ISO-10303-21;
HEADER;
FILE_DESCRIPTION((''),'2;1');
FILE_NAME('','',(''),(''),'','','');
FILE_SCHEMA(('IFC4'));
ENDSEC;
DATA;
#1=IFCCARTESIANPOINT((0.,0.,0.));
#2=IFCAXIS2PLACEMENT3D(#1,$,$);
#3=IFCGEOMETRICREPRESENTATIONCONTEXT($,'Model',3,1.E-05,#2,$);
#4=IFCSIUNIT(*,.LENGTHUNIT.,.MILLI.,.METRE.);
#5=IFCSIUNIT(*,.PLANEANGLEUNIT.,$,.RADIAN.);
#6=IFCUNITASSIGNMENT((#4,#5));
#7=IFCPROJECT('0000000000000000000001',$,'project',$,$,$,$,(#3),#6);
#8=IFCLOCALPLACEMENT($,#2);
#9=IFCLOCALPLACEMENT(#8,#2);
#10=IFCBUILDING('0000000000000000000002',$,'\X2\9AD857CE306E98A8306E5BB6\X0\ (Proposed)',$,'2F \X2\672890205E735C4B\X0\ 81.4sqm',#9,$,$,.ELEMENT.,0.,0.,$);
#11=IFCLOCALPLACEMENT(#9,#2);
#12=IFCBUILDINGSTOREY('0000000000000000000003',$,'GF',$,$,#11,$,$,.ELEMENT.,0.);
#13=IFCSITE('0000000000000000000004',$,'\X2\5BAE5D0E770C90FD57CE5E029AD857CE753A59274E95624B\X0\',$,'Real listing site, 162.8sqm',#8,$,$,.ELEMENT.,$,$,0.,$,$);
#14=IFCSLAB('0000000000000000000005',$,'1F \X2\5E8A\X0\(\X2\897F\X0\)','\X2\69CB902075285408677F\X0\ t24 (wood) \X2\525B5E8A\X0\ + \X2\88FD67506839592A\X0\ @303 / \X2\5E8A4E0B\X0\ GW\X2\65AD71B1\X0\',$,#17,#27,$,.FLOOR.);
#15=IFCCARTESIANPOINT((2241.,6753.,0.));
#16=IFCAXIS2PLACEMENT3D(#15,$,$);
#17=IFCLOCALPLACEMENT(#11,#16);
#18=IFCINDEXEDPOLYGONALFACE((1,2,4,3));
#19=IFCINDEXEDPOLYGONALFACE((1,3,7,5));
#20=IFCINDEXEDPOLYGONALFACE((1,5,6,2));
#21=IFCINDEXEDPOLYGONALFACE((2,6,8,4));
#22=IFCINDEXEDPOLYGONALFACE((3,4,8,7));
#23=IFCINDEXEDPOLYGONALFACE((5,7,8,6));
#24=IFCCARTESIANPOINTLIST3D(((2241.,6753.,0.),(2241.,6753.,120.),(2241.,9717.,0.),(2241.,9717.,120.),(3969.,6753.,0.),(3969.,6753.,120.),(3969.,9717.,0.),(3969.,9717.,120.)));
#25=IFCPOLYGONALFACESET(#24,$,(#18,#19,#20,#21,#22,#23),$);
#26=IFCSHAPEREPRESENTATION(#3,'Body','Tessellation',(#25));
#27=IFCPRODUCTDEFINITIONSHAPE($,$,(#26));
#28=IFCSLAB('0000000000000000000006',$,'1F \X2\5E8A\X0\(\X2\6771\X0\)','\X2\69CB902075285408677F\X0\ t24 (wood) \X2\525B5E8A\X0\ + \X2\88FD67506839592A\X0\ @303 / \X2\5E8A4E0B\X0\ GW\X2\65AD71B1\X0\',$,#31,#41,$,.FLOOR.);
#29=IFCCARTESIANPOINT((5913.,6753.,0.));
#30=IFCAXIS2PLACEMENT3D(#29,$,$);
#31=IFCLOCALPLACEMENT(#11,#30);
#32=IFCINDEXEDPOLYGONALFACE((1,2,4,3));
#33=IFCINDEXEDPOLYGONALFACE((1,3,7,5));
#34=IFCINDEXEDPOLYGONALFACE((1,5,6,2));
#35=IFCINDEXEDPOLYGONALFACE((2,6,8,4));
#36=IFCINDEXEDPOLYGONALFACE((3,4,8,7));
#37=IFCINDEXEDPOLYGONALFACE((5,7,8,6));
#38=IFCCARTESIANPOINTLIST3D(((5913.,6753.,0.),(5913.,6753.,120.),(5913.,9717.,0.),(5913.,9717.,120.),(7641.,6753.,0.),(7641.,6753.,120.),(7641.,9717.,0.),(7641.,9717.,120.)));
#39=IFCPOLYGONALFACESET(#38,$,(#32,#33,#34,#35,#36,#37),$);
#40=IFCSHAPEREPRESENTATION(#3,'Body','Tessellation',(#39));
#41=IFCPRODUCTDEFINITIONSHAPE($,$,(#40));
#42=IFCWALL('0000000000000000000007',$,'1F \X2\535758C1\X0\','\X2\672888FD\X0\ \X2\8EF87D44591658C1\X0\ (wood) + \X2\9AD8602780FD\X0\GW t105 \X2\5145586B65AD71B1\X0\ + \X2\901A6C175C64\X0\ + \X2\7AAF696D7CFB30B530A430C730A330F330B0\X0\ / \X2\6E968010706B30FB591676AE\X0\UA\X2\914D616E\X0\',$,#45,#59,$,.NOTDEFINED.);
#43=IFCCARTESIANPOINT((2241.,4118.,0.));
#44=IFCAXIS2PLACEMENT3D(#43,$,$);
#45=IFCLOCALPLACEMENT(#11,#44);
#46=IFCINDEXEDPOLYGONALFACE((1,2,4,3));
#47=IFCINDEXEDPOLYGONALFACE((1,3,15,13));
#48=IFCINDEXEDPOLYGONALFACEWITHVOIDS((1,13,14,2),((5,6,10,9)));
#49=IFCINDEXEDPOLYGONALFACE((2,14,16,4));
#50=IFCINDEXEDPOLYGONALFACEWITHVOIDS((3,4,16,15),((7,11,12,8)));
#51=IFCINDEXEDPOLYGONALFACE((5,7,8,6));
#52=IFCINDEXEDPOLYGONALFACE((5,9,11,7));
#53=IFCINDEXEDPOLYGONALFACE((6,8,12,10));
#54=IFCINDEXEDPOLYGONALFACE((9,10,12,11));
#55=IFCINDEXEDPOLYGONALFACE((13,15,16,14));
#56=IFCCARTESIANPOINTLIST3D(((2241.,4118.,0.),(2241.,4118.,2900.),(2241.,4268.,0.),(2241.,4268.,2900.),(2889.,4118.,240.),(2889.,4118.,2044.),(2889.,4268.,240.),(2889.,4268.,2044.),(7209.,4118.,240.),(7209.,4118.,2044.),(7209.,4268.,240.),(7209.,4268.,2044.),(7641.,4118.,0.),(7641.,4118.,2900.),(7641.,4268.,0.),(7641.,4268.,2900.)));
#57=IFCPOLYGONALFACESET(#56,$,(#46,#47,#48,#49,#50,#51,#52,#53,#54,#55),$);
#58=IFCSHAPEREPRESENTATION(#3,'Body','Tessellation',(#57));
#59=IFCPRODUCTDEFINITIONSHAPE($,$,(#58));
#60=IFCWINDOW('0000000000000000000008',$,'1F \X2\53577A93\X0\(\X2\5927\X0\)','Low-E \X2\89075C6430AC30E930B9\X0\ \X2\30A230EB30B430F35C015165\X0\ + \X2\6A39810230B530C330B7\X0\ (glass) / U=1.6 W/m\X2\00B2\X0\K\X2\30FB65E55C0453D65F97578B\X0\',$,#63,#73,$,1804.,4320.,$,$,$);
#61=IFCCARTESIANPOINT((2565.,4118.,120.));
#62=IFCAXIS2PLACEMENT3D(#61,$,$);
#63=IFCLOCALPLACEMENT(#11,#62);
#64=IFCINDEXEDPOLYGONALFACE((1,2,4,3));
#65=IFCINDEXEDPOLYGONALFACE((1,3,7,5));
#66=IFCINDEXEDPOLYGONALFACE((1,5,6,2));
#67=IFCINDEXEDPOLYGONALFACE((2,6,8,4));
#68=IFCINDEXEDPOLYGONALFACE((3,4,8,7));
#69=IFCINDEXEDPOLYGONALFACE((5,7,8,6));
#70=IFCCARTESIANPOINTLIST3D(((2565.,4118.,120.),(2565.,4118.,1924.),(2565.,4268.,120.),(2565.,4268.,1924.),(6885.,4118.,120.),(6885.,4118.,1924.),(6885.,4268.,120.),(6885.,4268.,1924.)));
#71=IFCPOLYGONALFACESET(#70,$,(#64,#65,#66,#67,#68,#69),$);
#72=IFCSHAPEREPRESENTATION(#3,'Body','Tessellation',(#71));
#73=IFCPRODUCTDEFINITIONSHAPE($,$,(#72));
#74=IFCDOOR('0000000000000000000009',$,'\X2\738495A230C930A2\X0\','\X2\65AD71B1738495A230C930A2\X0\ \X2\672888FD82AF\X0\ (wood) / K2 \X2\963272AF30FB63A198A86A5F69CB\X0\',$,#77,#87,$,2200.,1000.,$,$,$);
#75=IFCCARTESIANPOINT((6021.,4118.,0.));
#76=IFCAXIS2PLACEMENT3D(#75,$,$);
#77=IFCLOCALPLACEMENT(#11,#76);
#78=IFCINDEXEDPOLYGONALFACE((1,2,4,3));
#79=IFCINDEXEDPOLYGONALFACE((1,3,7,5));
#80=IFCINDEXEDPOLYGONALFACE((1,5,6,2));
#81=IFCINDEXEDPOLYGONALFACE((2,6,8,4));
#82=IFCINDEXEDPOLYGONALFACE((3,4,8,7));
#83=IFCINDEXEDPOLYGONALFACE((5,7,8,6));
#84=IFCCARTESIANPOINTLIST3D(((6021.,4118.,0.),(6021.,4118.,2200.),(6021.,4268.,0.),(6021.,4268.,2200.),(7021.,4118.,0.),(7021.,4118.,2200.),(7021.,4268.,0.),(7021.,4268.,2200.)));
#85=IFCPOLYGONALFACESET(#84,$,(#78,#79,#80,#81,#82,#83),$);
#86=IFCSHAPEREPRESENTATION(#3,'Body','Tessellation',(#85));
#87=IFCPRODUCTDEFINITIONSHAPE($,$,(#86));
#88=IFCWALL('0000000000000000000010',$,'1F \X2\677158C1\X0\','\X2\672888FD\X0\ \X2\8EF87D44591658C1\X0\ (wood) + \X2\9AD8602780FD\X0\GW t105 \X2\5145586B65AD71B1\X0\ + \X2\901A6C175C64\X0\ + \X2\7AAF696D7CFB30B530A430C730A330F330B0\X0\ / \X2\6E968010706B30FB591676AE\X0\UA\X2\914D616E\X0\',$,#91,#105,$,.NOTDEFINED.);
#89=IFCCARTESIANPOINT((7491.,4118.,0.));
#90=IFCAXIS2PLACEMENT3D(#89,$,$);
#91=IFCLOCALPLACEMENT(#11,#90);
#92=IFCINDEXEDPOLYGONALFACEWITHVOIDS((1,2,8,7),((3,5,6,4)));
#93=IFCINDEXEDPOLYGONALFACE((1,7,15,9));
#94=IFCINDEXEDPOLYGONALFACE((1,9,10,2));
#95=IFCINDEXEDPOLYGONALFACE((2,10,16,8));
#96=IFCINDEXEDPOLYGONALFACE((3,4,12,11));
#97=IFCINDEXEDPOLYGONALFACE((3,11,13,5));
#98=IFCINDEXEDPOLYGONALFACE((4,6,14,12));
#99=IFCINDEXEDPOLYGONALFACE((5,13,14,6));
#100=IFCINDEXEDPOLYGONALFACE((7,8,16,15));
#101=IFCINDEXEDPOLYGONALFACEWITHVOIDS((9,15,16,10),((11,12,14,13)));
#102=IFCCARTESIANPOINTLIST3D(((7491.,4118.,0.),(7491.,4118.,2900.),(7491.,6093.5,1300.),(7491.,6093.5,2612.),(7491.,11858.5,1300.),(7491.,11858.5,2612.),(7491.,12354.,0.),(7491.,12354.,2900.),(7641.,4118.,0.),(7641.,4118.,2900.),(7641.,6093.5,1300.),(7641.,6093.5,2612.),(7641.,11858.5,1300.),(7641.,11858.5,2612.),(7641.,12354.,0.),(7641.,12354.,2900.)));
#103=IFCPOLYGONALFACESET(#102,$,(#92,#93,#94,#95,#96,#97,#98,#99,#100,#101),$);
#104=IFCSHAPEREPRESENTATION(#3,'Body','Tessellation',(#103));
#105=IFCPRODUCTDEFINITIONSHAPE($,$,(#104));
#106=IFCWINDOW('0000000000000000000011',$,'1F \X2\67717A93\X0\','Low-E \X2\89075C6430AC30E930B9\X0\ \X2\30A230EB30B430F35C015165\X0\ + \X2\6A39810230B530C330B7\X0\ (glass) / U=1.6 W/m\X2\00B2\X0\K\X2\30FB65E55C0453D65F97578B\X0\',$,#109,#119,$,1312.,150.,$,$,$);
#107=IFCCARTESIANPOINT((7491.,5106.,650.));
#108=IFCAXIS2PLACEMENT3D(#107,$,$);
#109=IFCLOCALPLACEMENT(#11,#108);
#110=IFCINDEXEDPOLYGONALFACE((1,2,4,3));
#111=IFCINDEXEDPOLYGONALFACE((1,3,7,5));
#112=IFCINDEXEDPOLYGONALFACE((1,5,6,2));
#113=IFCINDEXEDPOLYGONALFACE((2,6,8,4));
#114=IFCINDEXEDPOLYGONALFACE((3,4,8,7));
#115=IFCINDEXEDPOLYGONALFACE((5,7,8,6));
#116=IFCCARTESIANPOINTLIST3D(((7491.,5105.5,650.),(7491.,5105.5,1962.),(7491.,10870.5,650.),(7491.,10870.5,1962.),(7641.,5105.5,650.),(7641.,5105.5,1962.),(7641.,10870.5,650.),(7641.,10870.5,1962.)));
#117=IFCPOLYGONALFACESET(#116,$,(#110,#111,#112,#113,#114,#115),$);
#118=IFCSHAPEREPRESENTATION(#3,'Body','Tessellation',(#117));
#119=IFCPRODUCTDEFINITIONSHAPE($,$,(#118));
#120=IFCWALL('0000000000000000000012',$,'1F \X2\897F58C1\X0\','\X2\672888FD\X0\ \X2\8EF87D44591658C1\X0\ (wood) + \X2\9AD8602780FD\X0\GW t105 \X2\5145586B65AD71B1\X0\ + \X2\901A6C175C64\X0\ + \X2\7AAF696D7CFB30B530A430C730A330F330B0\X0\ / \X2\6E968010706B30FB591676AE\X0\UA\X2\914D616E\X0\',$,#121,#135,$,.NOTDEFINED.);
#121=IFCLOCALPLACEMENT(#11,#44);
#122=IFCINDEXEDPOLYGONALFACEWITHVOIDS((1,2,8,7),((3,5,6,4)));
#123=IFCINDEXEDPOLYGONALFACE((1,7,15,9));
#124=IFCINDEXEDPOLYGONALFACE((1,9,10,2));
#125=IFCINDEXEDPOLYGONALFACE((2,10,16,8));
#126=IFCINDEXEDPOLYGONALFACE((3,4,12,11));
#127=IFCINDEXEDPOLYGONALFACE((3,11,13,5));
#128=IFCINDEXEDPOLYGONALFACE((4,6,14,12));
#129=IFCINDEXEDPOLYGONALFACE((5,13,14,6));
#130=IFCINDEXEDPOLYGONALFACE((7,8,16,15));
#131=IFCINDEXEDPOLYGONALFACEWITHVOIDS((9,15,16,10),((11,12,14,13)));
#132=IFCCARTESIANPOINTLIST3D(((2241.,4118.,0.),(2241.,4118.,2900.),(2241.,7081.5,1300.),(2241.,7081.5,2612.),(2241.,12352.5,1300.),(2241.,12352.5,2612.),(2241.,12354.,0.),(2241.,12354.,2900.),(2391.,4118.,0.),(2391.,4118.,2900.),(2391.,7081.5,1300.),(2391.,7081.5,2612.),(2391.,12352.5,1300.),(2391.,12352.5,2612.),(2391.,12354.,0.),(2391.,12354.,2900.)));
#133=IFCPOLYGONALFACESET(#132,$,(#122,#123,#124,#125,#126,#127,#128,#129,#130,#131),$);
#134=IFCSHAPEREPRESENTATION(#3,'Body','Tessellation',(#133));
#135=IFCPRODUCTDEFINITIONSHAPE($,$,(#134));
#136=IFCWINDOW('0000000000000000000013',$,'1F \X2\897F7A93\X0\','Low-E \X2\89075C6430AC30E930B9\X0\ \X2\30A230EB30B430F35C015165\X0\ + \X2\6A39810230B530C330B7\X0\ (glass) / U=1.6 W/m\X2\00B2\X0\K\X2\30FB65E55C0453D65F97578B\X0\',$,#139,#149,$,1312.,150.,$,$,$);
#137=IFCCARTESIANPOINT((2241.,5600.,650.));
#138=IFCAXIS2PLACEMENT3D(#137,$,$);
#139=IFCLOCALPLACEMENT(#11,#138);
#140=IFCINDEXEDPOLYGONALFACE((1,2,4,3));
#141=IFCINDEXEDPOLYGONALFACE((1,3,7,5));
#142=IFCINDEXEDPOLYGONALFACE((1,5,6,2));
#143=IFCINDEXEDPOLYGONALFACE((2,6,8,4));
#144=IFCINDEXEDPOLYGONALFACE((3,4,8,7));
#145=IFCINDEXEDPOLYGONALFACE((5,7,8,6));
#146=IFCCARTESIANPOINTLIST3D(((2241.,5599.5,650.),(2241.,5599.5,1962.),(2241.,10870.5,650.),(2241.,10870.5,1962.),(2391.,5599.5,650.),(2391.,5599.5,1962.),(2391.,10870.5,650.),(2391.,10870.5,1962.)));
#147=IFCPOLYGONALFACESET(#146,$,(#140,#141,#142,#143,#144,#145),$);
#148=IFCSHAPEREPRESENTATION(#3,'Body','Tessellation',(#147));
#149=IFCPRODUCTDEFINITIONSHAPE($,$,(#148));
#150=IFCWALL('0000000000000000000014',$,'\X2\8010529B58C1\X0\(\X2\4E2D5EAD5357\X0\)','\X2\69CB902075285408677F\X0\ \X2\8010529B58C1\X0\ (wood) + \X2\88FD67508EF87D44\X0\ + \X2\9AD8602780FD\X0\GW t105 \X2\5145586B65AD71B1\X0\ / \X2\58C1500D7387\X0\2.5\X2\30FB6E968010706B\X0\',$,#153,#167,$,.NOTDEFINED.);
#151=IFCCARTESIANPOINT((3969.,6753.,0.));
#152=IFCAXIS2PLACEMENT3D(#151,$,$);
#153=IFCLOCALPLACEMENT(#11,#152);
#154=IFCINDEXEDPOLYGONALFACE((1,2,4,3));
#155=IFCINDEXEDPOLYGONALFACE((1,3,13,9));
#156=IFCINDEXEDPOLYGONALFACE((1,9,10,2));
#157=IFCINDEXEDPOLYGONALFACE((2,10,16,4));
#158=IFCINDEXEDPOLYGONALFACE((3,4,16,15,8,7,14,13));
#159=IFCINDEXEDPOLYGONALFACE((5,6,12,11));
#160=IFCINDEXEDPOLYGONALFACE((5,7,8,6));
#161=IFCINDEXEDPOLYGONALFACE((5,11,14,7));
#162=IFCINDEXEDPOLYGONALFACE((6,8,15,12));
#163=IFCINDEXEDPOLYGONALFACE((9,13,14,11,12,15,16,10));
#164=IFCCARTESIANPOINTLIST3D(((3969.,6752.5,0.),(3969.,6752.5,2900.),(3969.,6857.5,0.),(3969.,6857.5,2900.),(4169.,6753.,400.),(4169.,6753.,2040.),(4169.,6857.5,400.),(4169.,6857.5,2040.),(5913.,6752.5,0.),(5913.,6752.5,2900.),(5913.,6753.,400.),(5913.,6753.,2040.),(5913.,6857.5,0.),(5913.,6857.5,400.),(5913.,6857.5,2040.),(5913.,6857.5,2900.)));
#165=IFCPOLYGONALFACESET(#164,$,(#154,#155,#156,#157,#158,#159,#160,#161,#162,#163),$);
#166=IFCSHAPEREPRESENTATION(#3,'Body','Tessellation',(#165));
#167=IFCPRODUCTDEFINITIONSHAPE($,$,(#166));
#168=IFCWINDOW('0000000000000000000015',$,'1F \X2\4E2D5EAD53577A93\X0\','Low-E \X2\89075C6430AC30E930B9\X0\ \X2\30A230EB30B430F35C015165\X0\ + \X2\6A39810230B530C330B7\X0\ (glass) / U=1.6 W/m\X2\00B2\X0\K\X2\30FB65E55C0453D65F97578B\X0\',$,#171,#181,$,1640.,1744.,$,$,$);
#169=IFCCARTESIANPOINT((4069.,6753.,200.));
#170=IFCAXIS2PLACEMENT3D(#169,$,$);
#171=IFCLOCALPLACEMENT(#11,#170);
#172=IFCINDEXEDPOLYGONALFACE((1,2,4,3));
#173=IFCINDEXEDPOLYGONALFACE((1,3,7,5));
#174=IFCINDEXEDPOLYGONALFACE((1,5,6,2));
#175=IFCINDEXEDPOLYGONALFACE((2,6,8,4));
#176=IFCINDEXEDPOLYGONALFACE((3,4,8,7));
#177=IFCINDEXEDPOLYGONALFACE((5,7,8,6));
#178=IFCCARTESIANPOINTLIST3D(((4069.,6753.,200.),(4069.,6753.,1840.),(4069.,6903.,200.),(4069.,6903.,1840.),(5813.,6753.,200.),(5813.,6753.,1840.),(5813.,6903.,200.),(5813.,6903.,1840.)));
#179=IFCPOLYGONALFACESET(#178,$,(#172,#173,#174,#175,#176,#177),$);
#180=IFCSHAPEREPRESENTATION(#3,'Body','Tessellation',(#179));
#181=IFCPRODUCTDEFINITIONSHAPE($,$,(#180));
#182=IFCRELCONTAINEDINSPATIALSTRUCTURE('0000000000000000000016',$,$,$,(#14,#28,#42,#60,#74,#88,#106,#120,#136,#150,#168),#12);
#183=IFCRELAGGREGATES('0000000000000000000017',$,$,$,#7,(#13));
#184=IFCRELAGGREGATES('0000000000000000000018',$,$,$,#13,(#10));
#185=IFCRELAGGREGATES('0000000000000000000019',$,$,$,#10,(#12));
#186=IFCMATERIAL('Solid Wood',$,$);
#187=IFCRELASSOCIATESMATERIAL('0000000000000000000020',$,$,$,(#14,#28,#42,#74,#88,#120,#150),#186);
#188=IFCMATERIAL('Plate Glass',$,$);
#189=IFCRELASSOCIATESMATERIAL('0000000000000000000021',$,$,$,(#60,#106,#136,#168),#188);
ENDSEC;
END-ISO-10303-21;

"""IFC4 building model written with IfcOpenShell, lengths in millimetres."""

from ifc_helpers import new_model, si_unit, frame, frame_2d, origin, place, context, project, spatial, rectangle, extrude, material, element, fill, save


model = new_model("IFC4")

# Units and contexts
model_context = context("Model", 3, precision=1e-05, world=origin())
ifc_project = project(units=[si_unit("LENGTHUNIT", "METRE", prefix="MILLI"), si_unit("PLANEANGLEUNIT", "RADIAN")], contexts=[model_context])

# Site, building, storey
site_placement = place(None, origin())
site = spatial("IfcSite", under=ifc_project, at=site_placement, Name="宮崎県都城市高城町大井手", ObjectType="Real listing site, 162.8sqm", CompositionType="ELEMENT", RefElevation=0.0)
building_placement = place(site_placement, origin())
building = spatial("IfcBuilding", under=site, at=building_placement, Name="高城の風の家 (Proposed)", ObjectType="2F 木造平屋 81.4sqm", CompositionType="ELEMENT", ElevationOfRefHeight=0.0, ElevationOfTerrain=0.0)
storey_placement = place(building_placement, origin())
storey = spatial("IfcBuildingStorey", under=building, at=storey_placement, Name="GF", CompositionType="ELEMENT", Elevation=0.0)

# Slabs
ifc_material_1 = material(Name="Solid Wood")
slab_1_placement = place(storey_placement, frame((2241.0, 6753.0, 0.0)))
element("IfcSlab", 1, at=slab_1_placement, inside=storey, material=ifc_material_1, Name="1F 床(西)", Description="構造用合板 t24 (wood) 剛床 + 製材根太 @303 / 床下 GW断熱", PredefinedType="FLOOR", context=model_context, shape_type="SweptSolid", body=[
    extrude(rectangle(XDim=1728.0, YDim=2964.0, at=frame_2d((864.0, 1482.0))), frame((2241.0, 6753.0, 0.0)), (0.0, 0.0, 1.0), 120.0),
])
slab_2_placement = place(storey_placement, frame((5913.0, 6753.0, 0.0)))
element("IfcSlab", 2, at=slab_2_placement, inside=storey, material=ifc_material_1, Name="1F 床(東)", Description="構造用合板 t24 (wood) 剛床 + 製材根太 @303 / 床下 GW断熱", PredefinedType="FLOOR", context=model_context, shape_type="SweptSolid", body=[
    extrude(rectangle(XDim=1728.0, YDim=2964.0, at=frame_2d((864.0, 1482.0))), frame((5913.0, 6753.0, 0.0)), (0.0, 0.0, 1.0), 120.0),
])

# Wall, openings, window, door
wall_1_placement = place(storey_placement, frame((2241.0, 4118.0, 0.0)))
wall_1 = element("IfcWall", 3, at=wall_1_placement, inside=storey, material=ifc_material_1, Name="1F 南壁", Description="木製 軸組外壁 (wood) + 高性能GW t105 充填断熱 + 通気層 + 窯業系サイディング / 準耐火・外皮UA配慮", PredefinedType="NOTDEFINED", context=model_context, shape_type="SweptSolid", body=[
    extrude(rectangle(XDim=5400.0, YDim=150.0, at=frame_2d((2700.0, 75.0))), frame((2241.0, 4118.0, 0.0)), (0.0, 0.0, 1.0), 2900.0),
])
opening_1_placement = place(storey_placement, frame((2565.0, 4118.0, 120.0)))
opening_1 = element("IfcOpeningElement", 4, at=opening_1_placement, cuts=wall_1, PredefinedType="NOTDEFINED", context=model_context, shape_type="SweptSolid", body=[
    extrude(rectangle(XDim=4320.0, YDim=150.0, at=frame_2d((2160.0, 75.0))), frame((2565.0, 4118.0, 120.0)), (0.0, 0.0, 1.0), 1804.0),
])
opening_2_placement = place(storey_placement, frame((6021.0, 4118.0, 0.0)))
opening_2 = element("IfcOpeningElement", 5, at=opening_2_placement, cuts=wall_1, PredefinedType="NOTDEFINED", context=model_context, shape_type="SweptSolid", body=[
    extrude(rectangle(XDim=1000.0, YDim=150.0, at=frame_2d((500.0, 75.0))), frame((6021.0, 4118.0, 0.0)), (0.0, 0.0, 1.0), 2200.0),
])
ifc_material_2 = material(Name="Plate Glass")
window_1_placement = place(storey_placement, frame((2565.0, 4118.0, 120.0)))
window_1 = element("IfcWindow", 6, at=window_1_placement, inside=storey, material=ifc_material_2, Name="1F 南窓(大)", Description="Low-E 複層ガラス アルゴン封入 + 樹脂サッシ (glass) / U=1.6 W/m²K・日射取得型", OverallHeight=1804.0, OverallWidth=4320.0, context=model_context, shape_type="SweptSolid", body=[
    extrude(rectangle(XDim=4320.0, YDim=150.0, at=frame_2d((2160.0, 75.0))), frame((2565.0, 4118.0, 120.0)), (0.0, 0.0, 1.0), 1804.0),
])
fill(opening_1, window_1)
door_placement = place(storey_placement, frame((6021.0, 4118.0, 0.0)))
door = element("IfcDoor", 7, at=door_placement, inside=storey, material=ifc_material_1, Name="玄関ドア", Description="断熱玄関ドア 木製芯 (wood) / K2 防犯・採風機構", OverallHeight=2200.0, OverallWidth=1000.0, context=model_context, shape_type="SweptSolid", body=[
    extrude(rectangle(XDim=1000.0, YDim=150.0, at=frame_2d((500.0, 75.0))), frame((6021.0, 4118.0, 0.0)), (0.0, 0.0, 1.0), 2200.0),
])
fill(opening_2, door)

# Walls, openings, windows
wall_2_placement = place(storey_placement, frame((7491.0, 4118.0, 0.0)))
wall_2 = element("IfcWall", 8, at=wall_2_placement, inside=storey, material=ifc_material_1, Name="1F 東壁", Description="木製 軸組外壁 (wood) + 高性能GW t105 充填断熱 + 通気層 + 窯業系サイディング / 準耐火・外皮UA配慮", PredefinedType="NOTDEFINED", context=model_context, shape_type="SweptSolid", body=[
    extrude(rectangle(XDim=150.0, YDim=8236.0, at=frame_2d((75.0, 4118.0))), frame((7491.0, 4118.0, 0.0)), (0.0, 0.0, 1.0), 2900.0),
])
opening_3_placement = place(storey_placement, frame((7491.0, 5106.0, 650.0)))
opening_3 = element("IfcOpeningElement", 9, at=opening_3_placement, cuts=wall_2, PredefinedType="NOTDEFINED", context=model_context, shape_type="SweptSolid", body=[
    extrude(rectangle(XDim=150.0, YDim=5765.0, at=frame_2d((75.0, 2882.0))), frame((7491.0, 5106.0, 650.0)), (0.0, 0.0, 1.0), 1312.0),
])
window_2_placement = place(storey_placement, frame((7491.0, 5106.0, 650.0)))
window_2 = element("IfcWindow", 10, at=window_2_placement, inside=storey, material=ifc_material_2, Name="1F 東窓", Description="Low-E 複層ガラス アルゴン封入 + 樹脂サッシ (glass) / U=1.6 W/m²K・日射取得型", OverallHeight=1312.0, OverallWidth=150.0, context=model_context, shape_type="SweptSolid", body=[
    extrude(rectangle(XDim=150.0, YDim=5765.0, at=frame_2d((75.0, 2882.0))), frame((7491.0, 5106.0, 650.0)), (0.0, 0.0, 1.0), 1312.0),
])
fill(opening_3, window_2)
wall_3_placement = place(storey_placement, frame((2241.0, 4118.0, 0.0)))
wall_3 = element("IfcWall", 11, at=wall_3_placement, inside=storey, material=ifc_material_1, Name="1F 西壁", Description="木製 軸組外壁 (wood) + 高性能GW t105 充填断熱 + 通気層 + 窯業系サイディング / 準耐火・外皮UA配慮", PredefinedType="NOTDEFINED", context=model_context, shape_type="SweptSolid", body=[
    extrude(rectangle(XDim=150.0, YDim=8236.0, at=frame_2d((75.0, 4118.0))), frame((2241.0, 4118.0, 0.0)), (0.0, 0.0, 1.0), 2900.0),
])
opening_4_placement = place(storey_placement, frame((2241.0, 5600.0, 650.0)))
opening_4 = element("IfcOpeningElement", 12, at=opening_4_placement, cuts=wall_3, PredefinedType="NOTDEFINED", context=model_context, shape_type="SweptSolid", body=[
    extrude(rectangle(XDim=150.0, YDim=5271.0, at=frame_2d((75.0, 2635.0))), frame((2241.0, 5600.0, 650.0)), (0.0, 0.0, 1.0), 1312.0),
])
window_3_placement = place(storey_placement, frame((2241.0, 5600.0, 650.0)))
window_3 = element("IfcWindow", 13, at=window_3_placement, inside=storey, material=ifc_material_2, Name="1F 西窓", Description="Low-E 複層ガラス アルゴン封入 + 樹脂サッシ (glass) / U=1.6 W/m²K・日射取得型", OverallHeight=1312.0, OverallWidth=150.0, context=model_context, shape_type="SweptSolid", body=[
    extrude(rectangle(XDim=150.0, YDim=5271.0, at=frame_2d((75.0, 2635.0))), frame((2241.0, 5600.0, 650.0)), (0.0, 0.0, 1.0), 1312.0),
])
fill(opening_4, window_3)
wall_4_placement = place(storey_placement, frame((3969.0, 6753.0, 0.0)))
wall_4 = element("IfcWall", 14, at=wall_4_placement, inside=storey, material=ifc_material_1, Name="耐力壁(中庭南)", Description="構造用合板 耐力壁 (wood) + 製材軸組 + 高性能GW t105 充填断熱 / 壁倍率2.5・準耐火", PredefinedType="NOTDEFINED", context=model_context, shape_type="SweptSolid", body=[
    extrude(rectangle(XDim=1944.0, YDim=105.0, at=frame_2d((972.0, 52.0))), frame((3969.0, 6753.0, 0.0)), (0.0, 0.0, 1.0), 2900.0),
])
opening_5_placement = place(storey_placement, frame((4069.0, 6753.0, 200.0)))
opening_5 = element("IfcOpeningElement", 15, at=opening_5_placement, cuts=wall_4, PredefinedType="NOTDEFINED", context=model_context, shape_type="SweptSolid", body=[
    extrude(rectangle(XDim=1744.0, YDim=150.0, at=frame_2d((872.0, 75.0))), frame((4069.0, 6753.0, 200.0)), (0.0, 0.0, 1.0), 1640.0),
])
window_4_placement = place(storey_placement, frame((4069.0, 6753.0, 200.0)))
window_4 = element("IfcWindow", 16, at=window_4_placement, inside=storey, material=ifc_material_2, Name="1F 中庭南窓", Description="Low-E 複層ガラス アルゴン封入 + 樹脂サッシ (glass) / U=1.6 W/m²K・日射取得型", OverallHeight=1640.0, OverallWidth=1744.0, context=model_context, shape_type="SweptSolid", body=[
    extrude(rectangle(XDim=1744.0, YDim=150.0, at=frame_2d((872.0, 75.0))), frame((4069.0, 6753.0, 200.0)), (0.0, 0.0, 1.0), 1640.0),
])
fill(opening_5, window_4)

save(model, "model.ifc")
